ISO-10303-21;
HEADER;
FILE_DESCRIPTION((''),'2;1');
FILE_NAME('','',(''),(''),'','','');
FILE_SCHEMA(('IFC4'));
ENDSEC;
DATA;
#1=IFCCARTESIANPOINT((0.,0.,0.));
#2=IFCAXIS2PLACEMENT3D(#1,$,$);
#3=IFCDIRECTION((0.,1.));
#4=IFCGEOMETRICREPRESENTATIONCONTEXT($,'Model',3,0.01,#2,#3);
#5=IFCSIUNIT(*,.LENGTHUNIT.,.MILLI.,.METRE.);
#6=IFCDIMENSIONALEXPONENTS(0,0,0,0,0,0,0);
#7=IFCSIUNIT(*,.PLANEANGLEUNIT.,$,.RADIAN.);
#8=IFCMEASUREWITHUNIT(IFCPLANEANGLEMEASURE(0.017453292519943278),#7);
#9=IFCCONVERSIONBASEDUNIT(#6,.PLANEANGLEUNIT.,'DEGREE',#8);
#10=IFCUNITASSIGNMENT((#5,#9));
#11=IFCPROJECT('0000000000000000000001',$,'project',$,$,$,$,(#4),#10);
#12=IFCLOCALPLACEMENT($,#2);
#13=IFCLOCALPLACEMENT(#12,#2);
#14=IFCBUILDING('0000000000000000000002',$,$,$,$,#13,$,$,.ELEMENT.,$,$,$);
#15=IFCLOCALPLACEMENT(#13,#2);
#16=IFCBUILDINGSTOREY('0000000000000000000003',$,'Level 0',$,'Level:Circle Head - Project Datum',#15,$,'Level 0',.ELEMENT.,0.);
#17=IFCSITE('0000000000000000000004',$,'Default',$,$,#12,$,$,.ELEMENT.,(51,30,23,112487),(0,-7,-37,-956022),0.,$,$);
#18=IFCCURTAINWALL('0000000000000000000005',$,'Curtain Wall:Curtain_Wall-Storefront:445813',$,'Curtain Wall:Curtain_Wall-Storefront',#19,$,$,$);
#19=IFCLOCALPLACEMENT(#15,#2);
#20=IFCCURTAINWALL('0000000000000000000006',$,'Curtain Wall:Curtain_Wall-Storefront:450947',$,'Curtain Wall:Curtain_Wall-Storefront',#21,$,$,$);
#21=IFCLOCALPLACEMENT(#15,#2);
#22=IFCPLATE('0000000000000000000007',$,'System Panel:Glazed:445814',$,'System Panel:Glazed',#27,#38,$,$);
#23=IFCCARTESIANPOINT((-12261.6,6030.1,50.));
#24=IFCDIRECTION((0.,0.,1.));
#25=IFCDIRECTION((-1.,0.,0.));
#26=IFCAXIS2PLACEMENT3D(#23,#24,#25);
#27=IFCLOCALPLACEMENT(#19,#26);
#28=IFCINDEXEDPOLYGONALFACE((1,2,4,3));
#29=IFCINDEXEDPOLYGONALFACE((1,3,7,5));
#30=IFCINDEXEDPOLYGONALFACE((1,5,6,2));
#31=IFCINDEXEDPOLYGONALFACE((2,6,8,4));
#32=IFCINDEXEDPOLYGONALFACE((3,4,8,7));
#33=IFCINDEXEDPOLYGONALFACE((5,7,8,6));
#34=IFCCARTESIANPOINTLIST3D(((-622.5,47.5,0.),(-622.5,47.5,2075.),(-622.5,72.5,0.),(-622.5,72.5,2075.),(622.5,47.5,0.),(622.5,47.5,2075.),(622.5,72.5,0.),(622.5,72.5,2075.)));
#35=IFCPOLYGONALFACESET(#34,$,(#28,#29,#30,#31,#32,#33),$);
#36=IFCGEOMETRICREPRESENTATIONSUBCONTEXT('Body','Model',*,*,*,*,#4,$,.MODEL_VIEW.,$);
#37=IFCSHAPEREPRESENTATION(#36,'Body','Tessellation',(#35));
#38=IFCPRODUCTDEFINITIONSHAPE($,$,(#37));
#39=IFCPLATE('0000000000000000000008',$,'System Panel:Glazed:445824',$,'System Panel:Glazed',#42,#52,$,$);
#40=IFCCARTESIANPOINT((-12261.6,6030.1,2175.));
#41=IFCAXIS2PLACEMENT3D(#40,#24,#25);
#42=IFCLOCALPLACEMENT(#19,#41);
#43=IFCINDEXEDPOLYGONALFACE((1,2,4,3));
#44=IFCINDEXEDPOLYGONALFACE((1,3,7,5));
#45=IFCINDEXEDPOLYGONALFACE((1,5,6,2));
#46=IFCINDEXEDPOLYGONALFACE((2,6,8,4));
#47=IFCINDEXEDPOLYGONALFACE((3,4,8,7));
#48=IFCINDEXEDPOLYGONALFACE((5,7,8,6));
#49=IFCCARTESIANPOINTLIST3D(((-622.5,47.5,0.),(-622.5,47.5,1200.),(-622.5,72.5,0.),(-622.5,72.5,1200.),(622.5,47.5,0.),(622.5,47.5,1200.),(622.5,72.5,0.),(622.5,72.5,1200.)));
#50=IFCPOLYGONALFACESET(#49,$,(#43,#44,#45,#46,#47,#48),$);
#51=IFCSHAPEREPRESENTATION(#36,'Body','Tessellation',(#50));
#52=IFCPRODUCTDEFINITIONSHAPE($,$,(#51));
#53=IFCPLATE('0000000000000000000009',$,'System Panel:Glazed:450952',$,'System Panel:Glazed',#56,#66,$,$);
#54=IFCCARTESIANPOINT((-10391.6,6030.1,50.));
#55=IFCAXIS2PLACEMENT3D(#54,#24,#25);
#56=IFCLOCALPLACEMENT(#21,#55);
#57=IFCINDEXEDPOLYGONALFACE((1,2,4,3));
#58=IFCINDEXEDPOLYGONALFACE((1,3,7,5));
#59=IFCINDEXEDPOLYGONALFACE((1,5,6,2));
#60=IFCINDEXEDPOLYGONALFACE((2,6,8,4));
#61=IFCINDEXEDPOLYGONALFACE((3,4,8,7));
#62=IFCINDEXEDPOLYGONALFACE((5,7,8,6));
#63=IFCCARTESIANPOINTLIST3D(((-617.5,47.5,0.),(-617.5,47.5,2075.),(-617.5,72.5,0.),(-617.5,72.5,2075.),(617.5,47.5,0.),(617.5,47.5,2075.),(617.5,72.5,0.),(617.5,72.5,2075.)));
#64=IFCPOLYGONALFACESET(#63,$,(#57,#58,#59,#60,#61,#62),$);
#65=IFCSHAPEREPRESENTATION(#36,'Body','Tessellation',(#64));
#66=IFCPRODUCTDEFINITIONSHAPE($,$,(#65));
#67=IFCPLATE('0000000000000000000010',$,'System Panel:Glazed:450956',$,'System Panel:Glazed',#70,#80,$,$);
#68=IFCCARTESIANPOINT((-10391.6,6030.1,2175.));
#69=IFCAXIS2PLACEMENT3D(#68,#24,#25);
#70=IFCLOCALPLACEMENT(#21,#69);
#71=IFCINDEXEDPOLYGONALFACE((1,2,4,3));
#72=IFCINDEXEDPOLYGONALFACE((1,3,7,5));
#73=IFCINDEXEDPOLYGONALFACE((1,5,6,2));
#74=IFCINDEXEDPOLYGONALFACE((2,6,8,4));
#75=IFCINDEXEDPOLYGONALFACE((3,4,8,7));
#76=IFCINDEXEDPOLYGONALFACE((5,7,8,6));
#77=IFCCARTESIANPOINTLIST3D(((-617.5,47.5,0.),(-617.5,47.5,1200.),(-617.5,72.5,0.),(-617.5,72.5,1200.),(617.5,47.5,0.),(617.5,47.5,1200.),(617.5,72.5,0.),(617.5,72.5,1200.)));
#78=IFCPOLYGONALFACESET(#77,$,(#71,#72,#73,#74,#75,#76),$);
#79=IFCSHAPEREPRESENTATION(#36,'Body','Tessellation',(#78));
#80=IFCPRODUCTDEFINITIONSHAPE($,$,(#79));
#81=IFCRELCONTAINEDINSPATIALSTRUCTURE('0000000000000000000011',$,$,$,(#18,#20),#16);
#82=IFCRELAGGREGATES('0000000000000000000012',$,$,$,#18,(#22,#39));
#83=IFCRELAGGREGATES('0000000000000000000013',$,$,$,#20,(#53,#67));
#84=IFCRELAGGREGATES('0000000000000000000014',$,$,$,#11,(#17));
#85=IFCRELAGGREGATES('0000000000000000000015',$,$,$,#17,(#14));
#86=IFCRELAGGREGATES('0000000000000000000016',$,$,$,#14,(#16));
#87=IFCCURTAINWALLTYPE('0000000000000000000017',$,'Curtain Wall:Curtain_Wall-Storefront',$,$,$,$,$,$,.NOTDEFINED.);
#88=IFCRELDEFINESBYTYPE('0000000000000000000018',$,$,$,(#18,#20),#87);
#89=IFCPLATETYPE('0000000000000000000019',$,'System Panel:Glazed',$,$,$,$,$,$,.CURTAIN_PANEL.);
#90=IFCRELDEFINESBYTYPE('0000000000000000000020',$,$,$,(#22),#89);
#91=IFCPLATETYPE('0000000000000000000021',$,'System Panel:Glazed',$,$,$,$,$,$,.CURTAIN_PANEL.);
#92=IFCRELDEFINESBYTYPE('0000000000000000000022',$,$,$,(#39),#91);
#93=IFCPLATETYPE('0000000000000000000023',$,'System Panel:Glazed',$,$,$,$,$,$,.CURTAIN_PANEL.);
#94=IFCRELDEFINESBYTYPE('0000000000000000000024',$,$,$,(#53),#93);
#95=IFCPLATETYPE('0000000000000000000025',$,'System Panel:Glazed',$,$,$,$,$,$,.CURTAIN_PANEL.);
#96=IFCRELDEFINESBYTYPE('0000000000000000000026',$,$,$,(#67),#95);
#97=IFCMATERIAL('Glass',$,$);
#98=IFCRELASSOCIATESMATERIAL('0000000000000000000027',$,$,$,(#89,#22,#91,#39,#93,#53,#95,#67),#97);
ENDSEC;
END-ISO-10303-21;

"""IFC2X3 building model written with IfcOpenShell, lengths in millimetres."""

from ifc_helpers import new_model, entity, si_unit, converted_unit, direction, frame, origin, origin_2d_with_axis, place, context, subcontext, project, spatial, rectangle, extrude, source, transform, mapped, material, type_object, type_shapes, element, aggregate, save


model = new_model("IFC2X3")

# Units and contexts
model_context = context("Model", 3, precision=0.01, world=origin(), true_north=direction((0.0, 1.0)))
body_context = subcontext(model_context, "Body", "Model", "MODEL_VIEW")
ifc_project = project(units=[si_unit("LENGTHUNIT", "METRE", prefix="MILLI"), converted_unit("PLANEANGLEUNIT", "DEGREE", entity("IfcPlaneAngleMeasure", 0.017453292519943278), si_unit("PLANEANGLEUNIT", "RADIAN"), dimensions=[0, 0, 0, 0, 0, 0, 0])], contexts=[model_context])

# Site, building, storey
site_placement = place(None, origin())
site = spatial("IfcSite", under=ifc_project, at=site_placement, Name="Default", CompositionType="ELEMENT", RefLatitude=(51, 30, 23, 112487), RefLongitude=(0, -7, -37, -956022), RefElevation=0.0)
building_placement = place(site_placement, origin())
building = spatial("IfcBuilding", under=site, at=building_placement, CompositionType="ELEMENT")
storey_placement = place(building_placement, origin())
storey = spatial("IfcBuildingStorey", under=building, at=storey_placement, Name="Level 0", ObjectType="Level:Circle Head - Project Datum", LongName="Level 0", CompositionType="ELEMENT", Elevation=0.0)

# Curtain walls
curtain_wall_type = type_object("IfcCurtainWallType", Name="Curtain Wall:Curtain_Wall-Storefront", PredefinedType="NOTDEFINED")
curtain_wall_1_placement = place(storey_placement, origin())
curtain_wall_1 = element("IfcCurtainWall", 1, at=curtain_wall_1_placement, inside=storey, type_object=curtain_wall_type, Name="Curtain Wall:Curtain_Wall-Storefront:445813", ObjectType="Curtain Wall:Curtain_Wall-Storefront")
curtain_wall_2_placement = place(storey_placement, origin())
curtain_wall_2 = element("IfcCurtainWall", 2, at=curtain_wall_2_placement, inside=storey, type_object=curtain_wall_type, Name="Curtain Wall:Curtain_Wall-Storefront:450947", ObjectType="Curtain Wall:Curtain_Wall-Storefront")

# Plates
ifc_material_1 = material(Name="Glass")
plate_type_1 = type_object("IfcPlateType", Name="System Panel:Glazed", PredefinedType="CURTAIN_PANEL", material=ifc_material_1)
shared_shape_1 = source(origin(), body_context, "Body", "SweptSolid", [
    extrude(rectangle(XDim=25.0, YDim=1245.0, at=origin_2d_with_axis()), frame((0.0, 60.0, 0.0), z_axis=(0.0, 0.0, 1.0), x_axis=(0.0, 1.0, 0.0)), (0.0, 0.0, 1.0), 2075.0),
])
type_shapes(plate_type_1, [shared_shape_1])
plate_1_placement = place(curtain_wall_1_placement, frame((-12261.6, 6030.1, 50.0), z_axis=(0.0, 0.0, 1.0), x_axis=(-1.0, 0.0, 0.0)))
plate_1 = element("IfcPlate", 3, at=plate_1_placement, type_object=plate_type_1, material=ifc_material_1, Name="System Panel:Glazed:445814", ObjectType="System Panel:Glazed", context=body_context, shape_type="MappedRepresentation", body=[
    mapped(shared_shape_1, transform((0.0, 0.0, 0.0), scale=1.0)),
])
plate_type_2 = type_object("IfcPlateType", Name="System Panel:Glazed", PredefinedType="CURTAIN_PANEL", material=ifc_material_1)
shared_shape_2 = source(origin(), body_context, "Body", "SweptSolid", [
    extrude(rectangle(XDim=25.0, YDim=1245.0, at=origin_2d_with_axis()), frame((0.0, 60.0, 0.0), z_axis=(0.0, 0.0, 1.0), x_axis=(0.0, 1.0, 0.0)), (0.0, 0.0, 1.0), 1200.0),
])
type_shapes(plate_type_2, [shared_shape_2])
plate_2_placement = place(curtain_wall_1_placement, frame((-12261.6, 6030.1, 2175.0), z_axis=(0.0, 0.0, 1.0), x_axis=(-1.0, 0.0, 0.0)))
plate_2 = element("IfcPlate", 4, at=plate_2_placement, type_object=plate_type_2, material=ifc_material_1, Name="System Panel:Glazed:445824", ObjectType="System Panel:Glazed", context=body_context, shape_type="MappedRepresentation", body=[
    mapped(shared_shape_2, transform((0.0, 0.0, 0.0), scale=1.0)),
])
aggregate(curtain_wall_1, [plate_1, plate_2])
plate_type_3 = type_object("IfcPlateType", Name="System Panel:Glazed", PredefinedType="CURTAIN_PANEL", material=ifc_material_1)
shared_shape_3 = source(origin(), body_context, "Body", "SweptSolid", [
    extrude(rectangle(XDim=25.0, YDim=1235.0, at=origin_2d_with_axis()), frame((0.0, 60.0, 0.0), z_axis=(0.0, 0.0, 1.0), x_axis=(0.0, 1.0, 0.0)), (0.0, 0.0, 1.0), 2075.0),
])
type_shapes(plate_type_3, [shared_shape_3])
plate_3_placement = place(curtain_wall_2_placement, frame((-10391.6, 6030.1, 50.0), z_axis=(0.0, 0.0, 1.0), x_axis=(-1.0, 0.0, 0.0)))
plate_3 = element("IfcPlate", 5, at=plate_3_placement, type_object=plate_type_3, material=ifc_material_1, Name="System Panel:Glazed:450952", ObjectType="System Panel:Glazed", context=body_context, shape_type="MappedRepresentation", body=[
    mapped(shared_shape_3, transform((0.0, 0.0, 0.0), scale=1.0)),
])
plate_type_4 = type_object("IfcPlateType", Name="System Panel:Glazed", PredefinedType="CURTAIN_PANEL", material=ifc_material_1)
shared_shape_4 = source(origin(), body_context, "Body", "SweptSolid", [
    extrude(rectangle(XDim=25.0, YDim=1235.0, at=origin_2d_with_axis()), frame((0.0, 60.0, 0.0), z_axis=(0.0, 0.0, 1.0), x_axis=(0.0, 1.0, 0.0)), (0.0, 0.0, 1.0), 1200.0),
])
type_shapes(plate_type_4, [shared_shape_4])
plate_4_placement = place(curtain_wall_2_placement, frame((-10391.6, 6030.1, 2175.0), z_axis=(0.0, 0.0, 1.0), x_axis=(-1.0, 0.0, 0.0)))
plate_4 = element("IfcPlate", 6, at=plate_4_placement, type_object=plate_type_4, material=ifc_material_1, Name="System Panel:Glazed:450956", ObjectType="System Panel:Glazed", context=body_context, shape_type="MappedRepresentation", body=[
    mapped(shared_shape_4, transform((0.0, 0.0, 0.0), scale=1.0)),
])
aggregate(curtain_wall_2, [plate_3, plate_4])

save(model, "model.ifc")
